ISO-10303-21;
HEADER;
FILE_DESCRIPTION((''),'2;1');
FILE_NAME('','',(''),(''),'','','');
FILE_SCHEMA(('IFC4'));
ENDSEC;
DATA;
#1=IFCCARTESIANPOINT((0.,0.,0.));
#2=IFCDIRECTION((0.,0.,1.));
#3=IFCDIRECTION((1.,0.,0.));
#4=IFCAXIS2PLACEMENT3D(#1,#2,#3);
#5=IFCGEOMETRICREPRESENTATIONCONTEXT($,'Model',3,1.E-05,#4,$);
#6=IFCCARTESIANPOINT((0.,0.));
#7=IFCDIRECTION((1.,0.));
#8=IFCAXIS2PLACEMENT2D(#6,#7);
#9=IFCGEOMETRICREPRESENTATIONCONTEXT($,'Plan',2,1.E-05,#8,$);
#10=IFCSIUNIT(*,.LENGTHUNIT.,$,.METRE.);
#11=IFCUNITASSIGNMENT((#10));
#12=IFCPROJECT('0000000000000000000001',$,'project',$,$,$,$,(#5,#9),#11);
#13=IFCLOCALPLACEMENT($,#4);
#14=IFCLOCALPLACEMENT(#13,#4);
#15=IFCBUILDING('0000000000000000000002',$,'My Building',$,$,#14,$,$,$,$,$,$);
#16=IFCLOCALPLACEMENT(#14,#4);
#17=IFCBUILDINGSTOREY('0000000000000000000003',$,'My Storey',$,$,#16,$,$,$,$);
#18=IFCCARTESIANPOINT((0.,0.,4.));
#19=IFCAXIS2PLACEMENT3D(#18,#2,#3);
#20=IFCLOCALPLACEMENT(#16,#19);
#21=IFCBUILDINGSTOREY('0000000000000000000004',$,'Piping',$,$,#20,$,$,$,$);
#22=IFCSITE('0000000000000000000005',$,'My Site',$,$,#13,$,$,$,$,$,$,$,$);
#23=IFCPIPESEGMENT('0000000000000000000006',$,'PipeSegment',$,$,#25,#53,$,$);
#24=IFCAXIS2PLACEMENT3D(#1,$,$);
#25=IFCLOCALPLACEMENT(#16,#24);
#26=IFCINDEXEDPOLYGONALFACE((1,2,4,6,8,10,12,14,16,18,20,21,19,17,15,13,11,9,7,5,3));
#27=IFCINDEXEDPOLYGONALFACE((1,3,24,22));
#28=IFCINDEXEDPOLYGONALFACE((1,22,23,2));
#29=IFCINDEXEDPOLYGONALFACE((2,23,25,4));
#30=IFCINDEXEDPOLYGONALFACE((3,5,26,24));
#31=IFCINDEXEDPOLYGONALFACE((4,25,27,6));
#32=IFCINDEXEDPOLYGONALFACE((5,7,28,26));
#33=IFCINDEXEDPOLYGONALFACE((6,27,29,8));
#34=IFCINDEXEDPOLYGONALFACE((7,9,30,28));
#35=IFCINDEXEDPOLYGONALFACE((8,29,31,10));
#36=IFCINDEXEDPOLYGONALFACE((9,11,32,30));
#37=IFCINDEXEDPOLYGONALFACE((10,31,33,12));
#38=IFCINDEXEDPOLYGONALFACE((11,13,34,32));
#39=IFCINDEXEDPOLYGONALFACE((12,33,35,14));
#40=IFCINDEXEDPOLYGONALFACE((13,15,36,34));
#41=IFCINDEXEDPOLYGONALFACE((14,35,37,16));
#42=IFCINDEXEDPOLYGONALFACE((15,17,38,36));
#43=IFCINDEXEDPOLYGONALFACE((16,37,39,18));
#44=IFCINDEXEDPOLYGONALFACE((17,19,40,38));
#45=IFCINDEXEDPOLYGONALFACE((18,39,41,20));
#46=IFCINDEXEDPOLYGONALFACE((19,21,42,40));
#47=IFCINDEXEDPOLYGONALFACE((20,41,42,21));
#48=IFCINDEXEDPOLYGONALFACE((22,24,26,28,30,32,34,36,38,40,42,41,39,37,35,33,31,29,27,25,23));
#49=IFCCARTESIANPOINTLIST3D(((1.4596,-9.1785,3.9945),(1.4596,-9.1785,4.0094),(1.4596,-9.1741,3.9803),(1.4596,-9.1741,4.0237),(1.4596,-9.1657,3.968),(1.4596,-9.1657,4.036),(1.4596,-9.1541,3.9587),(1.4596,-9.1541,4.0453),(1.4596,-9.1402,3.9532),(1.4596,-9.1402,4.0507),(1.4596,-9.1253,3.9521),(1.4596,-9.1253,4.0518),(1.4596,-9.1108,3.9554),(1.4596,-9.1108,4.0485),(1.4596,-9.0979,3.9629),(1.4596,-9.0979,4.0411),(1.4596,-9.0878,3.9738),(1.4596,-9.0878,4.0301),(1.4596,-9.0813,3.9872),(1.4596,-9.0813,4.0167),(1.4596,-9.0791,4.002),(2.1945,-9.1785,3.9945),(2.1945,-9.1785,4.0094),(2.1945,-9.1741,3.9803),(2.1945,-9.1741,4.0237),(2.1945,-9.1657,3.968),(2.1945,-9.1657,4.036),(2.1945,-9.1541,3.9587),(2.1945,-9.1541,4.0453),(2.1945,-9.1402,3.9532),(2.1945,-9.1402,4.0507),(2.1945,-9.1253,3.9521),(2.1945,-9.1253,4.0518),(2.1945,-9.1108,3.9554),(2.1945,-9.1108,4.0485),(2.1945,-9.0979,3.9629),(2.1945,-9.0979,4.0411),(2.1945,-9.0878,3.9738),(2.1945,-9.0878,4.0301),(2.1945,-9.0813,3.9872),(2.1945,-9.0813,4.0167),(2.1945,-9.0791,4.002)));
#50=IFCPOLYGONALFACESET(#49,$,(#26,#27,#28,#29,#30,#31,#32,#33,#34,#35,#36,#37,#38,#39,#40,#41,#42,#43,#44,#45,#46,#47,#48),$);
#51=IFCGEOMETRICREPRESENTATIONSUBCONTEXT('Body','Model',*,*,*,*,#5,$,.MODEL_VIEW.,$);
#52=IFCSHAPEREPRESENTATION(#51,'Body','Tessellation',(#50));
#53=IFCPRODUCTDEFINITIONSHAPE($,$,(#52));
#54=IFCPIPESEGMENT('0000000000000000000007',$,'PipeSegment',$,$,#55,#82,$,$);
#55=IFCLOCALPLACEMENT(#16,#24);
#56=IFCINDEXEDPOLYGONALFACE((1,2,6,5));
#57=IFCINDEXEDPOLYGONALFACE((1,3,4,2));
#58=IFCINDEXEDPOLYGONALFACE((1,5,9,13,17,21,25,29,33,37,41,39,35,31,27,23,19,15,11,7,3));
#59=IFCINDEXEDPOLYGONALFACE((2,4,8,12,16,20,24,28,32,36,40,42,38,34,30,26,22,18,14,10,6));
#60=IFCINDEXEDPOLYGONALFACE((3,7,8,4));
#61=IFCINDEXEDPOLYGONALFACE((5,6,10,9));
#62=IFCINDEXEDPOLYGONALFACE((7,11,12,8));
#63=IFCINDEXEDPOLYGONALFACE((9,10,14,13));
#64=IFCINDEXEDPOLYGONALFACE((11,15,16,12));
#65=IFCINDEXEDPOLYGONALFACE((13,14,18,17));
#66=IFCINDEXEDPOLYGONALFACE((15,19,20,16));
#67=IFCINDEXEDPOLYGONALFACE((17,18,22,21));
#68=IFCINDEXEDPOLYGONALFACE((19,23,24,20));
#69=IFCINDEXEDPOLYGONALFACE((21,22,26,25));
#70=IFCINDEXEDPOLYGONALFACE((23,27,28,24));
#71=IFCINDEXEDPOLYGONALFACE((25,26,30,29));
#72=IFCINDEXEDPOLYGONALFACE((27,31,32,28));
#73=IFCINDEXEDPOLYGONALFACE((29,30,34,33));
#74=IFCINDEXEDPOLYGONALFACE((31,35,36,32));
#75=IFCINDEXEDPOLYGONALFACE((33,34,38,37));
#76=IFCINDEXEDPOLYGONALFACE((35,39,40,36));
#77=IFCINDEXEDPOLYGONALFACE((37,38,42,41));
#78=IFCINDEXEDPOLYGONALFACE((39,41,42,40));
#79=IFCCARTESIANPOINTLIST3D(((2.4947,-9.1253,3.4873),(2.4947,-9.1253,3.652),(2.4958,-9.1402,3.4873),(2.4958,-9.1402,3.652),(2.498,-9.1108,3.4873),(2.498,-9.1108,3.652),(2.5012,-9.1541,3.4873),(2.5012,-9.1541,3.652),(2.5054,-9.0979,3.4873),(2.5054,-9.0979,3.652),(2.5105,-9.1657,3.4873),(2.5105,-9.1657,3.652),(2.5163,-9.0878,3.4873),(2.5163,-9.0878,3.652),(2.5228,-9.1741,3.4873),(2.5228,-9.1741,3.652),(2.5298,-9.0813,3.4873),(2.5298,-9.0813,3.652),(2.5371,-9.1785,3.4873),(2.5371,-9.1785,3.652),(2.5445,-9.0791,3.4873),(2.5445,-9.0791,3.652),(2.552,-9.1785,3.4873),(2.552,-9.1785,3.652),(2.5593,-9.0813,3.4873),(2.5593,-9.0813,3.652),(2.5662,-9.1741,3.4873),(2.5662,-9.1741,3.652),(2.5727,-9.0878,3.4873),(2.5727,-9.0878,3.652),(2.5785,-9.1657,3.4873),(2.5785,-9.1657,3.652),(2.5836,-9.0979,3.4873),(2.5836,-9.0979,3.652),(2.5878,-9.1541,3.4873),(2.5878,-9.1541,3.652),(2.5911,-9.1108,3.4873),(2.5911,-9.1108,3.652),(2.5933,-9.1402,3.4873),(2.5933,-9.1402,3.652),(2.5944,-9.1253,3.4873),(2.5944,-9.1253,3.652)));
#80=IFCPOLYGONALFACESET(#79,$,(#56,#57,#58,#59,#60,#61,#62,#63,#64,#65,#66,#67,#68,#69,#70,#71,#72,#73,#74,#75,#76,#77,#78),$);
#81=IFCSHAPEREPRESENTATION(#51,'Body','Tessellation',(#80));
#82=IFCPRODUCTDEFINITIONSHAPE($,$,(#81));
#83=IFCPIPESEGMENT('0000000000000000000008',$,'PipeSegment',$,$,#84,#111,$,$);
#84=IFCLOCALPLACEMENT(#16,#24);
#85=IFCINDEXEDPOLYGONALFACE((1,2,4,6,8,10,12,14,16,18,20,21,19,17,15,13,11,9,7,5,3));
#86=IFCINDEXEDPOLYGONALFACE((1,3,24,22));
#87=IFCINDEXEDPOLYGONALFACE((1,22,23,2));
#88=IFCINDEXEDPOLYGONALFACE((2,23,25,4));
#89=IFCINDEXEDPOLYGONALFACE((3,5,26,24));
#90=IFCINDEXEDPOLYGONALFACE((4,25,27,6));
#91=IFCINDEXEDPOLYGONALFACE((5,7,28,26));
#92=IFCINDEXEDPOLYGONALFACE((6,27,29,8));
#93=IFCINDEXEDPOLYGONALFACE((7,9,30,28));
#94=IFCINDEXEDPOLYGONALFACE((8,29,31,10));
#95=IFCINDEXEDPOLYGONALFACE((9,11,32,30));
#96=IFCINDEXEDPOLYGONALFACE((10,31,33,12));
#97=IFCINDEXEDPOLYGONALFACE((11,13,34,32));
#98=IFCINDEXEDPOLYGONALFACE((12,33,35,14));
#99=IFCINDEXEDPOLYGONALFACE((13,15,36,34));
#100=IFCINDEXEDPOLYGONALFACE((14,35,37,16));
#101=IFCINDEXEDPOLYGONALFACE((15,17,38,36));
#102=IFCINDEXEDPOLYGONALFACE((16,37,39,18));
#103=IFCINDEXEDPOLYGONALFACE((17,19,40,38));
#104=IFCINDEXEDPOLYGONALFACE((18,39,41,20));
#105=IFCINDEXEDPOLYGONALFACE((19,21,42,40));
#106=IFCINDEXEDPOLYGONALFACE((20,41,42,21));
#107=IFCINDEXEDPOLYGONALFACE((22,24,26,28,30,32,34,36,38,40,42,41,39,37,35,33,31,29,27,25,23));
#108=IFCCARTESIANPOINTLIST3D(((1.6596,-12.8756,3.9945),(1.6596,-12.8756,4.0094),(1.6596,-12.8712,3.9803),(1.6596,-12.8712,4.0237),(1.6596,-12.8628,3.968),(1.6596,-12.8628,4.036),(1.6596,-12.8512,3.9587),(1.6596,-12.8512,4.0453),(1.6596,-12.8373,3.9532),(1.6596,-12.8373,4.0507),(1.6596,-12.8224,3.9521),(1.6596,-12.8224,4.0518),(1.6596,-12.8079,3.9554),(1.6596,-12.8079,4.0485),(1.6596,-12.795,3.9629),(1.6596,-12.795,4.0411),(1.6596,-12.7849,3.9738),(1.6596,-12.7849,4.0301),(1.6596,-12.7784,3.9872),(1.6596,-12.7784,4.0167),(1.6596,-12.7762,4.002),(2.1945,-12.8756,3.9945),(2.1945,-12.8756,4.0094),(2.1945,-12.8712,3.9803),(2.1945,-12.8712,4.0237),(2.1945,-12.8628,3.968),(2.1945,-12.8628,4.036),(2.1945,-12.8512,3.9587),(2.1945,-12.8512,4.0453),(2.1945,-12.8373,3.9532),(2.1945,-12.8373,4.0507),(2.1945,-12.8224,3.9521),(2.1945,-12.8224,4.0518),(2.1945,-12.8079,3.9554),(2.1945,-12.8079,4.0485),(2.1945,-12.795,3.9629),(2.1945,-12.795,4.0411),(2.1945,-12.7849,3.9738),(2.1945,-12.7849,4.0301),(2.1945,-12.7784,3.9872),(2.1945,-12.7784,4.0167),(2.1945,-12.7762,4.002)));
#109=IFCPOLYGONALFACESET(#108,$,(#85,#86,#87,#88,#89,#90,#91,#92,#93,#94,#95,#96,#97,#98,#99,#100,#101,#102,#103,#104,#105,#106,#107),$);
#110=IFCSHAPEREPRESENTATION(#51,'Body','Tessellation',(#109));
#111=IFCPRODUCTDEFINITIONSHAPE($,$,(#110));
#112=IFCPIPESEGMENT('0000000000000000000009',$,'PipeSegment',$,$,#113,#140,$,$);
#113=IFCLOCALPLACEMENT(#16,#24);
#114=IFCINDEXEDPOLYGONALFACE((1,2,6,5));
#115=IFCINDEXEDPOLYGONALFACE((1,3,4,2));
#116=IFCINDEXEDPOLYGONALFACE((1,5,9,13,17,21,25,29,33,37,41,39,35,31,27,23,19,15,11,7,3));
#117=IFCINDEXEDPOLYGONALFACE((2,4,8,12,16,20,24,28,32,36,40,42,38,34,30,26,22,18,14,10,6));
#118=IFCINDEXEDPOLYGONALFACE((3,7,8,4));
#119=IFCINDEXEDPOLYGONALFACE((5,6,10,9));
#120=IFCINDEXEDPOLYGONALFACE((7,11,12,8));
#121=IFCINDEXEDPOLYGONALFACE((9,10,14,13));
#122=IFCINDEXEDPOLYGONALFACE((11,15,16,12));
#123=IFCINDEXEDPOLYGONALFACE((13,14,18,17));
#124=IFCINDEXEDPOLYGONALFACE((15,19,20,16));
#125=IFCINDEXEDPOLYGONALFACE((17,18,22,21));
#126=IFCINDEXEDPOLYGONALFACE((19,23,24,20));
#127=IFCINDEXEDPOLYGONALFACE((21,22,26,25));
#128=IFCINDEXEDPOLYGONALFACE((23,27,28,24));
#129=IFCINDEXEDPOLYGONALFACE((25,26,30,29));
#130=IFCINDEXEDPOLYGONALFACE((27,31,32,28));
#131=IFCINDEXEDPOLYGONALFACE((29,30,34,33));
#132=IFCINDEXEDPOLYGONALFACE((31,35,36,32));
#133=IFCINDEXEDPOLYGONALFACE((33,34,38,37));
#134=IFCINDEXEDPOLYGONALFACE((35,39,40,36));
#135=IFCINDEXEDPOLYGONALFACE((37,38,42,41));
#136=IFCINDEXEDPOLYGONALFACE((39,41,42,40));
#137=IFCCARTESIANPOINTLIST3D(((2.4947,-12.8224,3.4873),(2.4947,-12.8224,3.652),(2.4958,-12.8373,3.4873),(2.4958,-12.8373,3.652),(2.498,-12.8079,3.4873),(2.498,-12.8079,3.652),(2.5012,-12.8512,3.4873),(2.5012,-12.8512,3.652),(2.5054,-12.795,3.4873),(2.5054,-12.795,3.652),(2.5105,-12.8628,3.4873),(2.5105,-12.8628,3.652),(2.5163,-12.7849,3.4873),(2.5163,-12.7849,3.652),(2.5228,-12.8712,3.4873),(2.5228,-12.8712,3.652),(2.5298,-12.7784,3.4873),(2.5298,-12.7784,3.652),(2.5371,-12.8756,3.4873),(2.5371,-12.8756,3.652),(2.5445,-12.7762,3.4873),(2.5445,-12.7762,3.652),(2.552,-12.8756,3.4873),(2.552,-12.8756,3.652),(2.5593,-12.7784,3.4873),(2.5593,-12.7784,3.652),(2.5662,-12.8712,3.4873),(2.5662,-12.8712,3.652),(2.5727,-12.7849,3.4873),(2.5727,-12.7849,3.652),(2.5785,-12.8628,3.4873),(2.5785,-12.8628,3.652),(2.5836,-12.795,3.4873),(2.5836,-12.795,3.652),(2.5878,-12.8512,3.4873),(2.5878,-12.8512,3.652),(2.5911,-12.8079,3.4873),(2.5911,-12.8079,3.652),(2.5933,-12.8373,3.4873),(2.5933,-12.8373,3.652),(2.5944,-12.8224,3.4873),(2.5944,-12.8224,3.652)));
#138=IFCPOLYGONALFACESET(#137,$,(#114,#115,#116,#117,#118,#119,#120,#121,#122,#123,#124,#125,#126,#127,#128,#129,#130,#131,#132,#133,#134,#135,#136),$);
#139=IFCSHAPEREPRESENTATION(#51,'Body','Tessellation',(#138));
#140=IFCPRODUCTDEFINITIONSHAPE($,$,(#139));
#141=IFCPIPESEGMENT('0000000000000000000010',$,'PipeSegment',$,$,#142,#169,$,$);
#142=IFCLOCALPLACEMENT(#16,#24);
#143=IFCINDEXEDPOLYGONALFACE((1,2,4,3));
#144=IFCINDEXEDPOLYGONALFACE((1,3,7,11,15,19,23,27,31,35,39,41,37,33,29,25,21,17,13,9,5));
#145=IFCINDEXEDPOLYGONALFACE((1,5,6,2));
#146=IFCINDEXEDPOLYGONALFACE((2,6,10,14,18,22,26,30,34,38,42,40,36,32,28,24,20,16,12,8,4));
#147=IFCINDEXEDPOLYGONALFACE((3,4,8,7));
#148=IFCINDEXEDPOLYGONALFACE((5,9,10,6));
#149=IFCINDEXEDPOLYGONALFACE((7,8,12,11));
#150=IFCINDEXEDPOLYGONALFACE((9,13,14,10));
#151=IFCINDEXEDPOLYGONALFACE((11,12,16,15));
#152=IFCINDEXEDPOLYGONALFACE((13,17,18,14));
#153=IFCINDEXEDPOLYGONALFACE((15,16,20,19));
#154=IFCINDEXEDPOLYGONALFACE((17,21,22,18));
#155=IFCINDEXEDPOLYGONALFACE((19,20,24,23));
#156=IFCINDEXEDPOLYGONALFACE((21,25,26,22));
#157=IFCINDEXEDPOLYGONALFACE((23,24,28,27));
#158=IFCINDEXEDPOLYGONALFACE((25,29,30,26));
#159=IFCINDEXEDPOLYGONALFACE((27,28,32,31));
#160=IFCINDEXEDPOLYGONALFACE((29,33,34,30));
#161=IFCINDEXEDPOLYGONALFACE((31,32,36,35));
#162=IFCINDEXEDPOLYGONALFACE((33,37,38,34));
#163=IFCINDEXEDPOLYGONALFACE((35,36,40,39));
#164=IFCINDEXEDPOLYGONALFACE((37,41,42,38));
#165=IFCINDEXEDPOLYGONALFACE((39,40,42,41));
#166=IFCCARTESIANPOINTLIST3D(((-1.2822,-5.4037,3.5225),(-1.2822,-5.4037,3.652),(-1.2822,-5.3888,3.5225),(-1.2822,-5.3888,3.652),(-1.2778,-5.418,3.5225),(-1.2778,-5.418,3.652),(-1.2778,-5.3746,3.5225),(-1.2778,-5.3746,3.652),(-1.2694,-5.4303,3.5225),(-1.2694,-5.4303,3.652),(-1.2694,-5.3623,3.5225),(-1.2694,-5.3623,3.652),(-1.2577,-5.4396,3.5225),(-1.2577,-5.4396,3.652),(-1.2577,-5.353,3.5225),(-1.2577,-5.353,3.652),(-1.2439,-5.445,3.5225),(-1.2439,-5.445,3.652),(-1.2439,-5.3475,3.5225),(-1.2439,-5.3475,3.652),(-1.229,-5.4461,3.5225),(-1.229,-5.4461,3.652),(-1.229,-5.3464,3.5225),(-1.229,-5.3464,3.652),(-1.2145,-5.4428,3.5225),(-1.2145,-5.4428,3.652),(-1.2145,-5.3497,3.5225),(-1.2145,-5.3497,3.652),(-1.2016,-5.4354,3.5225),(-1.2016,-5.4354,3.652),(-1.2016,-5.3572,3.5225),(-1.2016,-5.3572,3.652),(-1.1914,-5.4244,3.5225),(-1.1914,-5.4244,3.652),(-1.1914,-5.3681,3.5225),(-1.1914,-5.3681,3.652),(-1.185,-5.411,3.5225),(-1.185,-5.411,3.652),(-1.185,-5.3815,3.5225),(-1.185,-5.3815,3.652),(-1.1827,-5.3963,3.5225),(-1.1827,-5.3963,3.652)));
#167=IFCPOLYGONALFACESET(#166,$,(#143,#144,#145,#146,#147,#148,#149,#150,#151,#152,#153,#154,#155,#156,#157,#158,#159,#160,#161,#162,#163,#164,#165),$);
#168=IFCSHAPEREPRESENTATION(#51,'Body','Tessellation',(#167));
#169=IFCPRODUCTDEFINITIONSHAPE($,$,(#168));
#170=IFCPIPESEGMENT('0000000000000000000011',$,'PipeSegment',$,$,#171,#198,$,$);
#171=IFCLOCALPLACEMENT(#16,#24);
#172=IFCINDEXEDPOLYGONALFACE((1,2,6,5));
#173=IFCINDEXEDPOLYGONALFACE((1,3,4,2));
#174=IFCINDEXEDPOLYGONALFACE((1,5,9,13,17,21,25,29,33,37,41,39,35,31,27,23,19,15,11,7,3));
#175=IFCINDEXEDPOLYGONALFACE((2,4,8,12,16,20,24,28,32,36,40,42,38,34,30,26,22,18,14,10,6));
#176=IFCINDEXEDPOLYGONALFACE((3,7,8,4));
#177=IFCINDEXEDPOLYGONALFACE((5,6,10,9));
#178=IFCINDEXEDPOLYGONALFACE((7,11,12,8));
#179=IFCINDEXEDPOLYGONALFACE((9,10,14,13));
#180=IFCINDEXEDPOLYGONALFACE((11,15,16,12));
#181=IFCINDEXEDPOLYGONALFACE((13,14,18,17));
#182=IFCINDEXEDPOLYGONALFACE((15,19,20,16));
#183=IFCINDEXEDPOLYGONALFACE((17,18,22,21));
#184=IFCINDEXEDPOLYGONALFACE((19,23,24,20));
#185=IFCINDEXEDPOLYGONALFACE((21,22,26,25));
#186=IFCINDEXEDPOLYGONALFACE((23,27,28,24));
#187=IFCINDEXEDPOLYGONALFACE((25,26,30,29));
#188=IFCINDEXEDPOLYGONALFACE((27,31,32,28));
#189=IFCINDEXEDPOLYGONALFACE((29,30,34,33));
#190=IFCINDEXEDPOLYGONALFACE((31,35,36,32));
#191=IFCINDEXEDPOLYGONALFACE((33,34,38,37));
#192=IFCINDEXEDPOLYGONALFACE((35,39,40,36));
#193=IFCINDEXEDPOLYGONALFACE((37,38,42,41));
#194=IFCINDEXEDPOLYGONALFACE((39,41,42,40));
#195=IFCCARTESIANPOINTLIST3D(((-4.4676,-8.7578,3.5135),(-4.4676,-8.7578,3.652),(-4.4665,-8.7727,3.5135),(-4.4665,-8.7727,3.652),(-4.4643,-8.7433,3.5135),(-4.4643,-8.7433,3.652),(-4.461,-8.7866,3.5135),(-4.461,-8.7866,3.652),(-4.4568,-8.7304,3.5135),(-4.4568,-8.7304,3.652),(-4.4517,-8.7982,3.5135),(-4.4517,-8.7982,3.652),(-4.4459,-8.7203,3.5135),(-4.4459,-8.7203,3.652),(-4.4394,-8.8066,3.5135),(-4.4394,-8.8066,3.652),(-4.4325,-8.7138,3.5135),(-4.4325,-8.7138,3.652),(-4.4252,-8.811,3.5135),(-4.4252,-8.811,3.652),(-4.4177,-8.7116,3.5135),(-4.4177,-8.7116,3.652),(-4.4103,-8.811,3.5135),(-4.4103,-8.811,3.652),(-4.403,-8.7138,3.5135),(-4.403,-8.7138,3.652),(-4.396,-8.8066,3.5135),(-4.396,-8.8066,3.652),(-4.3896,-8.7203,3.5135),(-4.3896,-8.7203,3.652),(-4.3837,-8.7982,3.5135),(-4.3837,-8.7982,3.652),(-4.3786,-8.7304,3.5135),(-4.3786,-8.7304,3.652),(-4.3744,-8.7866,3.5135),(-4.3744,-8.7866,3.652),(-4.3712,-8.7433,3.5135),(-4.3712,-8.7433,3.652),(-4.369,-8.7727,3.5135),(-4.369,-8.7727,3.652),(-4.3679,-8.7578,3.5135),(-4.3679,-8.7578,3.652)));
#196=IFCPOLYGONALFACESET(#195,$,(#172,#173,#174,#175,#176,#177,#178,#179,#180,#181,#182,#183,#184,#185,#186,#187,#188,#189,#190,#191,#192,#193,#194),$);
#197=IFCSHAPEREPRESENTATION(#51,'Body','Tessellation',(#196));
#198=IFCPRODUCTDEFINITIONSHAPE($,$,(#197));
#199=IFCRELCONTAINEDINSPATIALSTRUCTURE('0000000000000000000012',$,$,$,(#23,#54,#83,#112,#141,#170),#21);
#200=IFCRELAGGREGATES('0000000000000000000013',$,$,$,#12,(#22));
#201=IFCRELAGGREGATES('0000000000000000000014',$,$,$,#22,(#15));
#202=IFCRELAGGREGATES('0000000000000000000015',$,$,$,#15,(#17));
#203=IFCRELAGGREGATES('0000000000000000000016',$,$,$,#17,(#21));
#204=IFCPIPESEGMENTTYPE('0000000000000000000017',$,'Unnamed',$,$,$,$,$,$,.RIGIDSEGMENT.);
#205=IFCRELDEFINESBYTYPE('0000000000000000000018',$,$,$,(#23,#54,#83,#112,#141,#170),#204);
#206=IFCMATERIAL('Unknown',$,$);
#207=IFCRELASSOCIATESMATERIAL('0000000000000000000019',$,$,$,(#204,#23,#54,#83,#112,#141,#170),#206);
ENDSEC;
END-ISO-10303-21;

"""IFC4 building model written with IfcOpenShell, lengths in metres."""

from ifc_helpers import new_model, si_unit, frame, origin_with_axes, origin_2d_with_axis, place, context, subcontext, project, spatial, circle, extrude, material, material_profile, profile_set, profile_usage, type_object, element, save


model = new_model("IFC4")

# Units and contexts
model_context = context("Model", 3, precision=1e-05, world=origin_with_axes())
plan_context = context("Plan", 2, precision=1e-05, world=origin_2d_with_axis())
body_context = subcontext(model_context, "Body", "Model", "MODEL_VIEW")
ifc_project = project(units=[si_unit("LENGTHUNIT", "METRE")], contexts=[model_context, plan_context])

# Site, building, storeys
site_placement = place(None, origin_with_axes())
site = spatial("IfcSite", under=ifc_project, at=site_placement, Name="My Site")
building_placement = place(site_placement, origin_with_axes())
building = spatial("IfcBuilding", under=site, at=building_placement, Name="My Building")
storey_1_placement = place(building_placement, origin_with_axes())
storey_1 = spatial("IfcBuildingStorey", under=building, at=storey_1_placement, Name="My Storey")
storey_2_placement = place(storey_1_placement, frame((0.0, 0.0, 4.0), z_axis=(0.0, 0.0, 1.0), x_axis=(1.0, 0.0, 0.0)))
storey_2 = spatial("IfcBuildingStorey", under=storey_1, at=storey_2_placement, Name="Piping")

# Pipe segments
ifc_material = material(Name="Unknown")
ifc_material_profile_1 = material_profile(ifc_material, circle(Radius=0.05))
ifc_profile_set_1 = profile_set([ifc_material_profile_1])
ifc_profile_usage_1 = profile_usage(ifc_profile_set_1, cardinal=5)
pipe_segment_type = type_object("IfcPipeSegmentType", Name="Unnamed", PredefinedType="RIGIDSEGMENT", material=ifc_profile_set_1)
pipe_segment_1_placement = place(storey_2_placement, frame((1.4596, -9.1291, 0.002), z_axis=(1.0, 0.0, 0.0), x_axis=(0.0, 1.0, 0.0)))
element("IfcPipeSegment", 1, at=pipe_segment_1_placement, inside=storey_2, type_object=pipe_segment_type, material=ifc_profile_usage_1, Name="PipeSegment", context=body_context, shape_type="SweptSolid", body=[
    extrude(circle(Radius=0.05), origin_with_axes(), (0.0, 0.0, 1.0), 0.735),
])
ifc_profile_usage_2 = profile_usage(ifc_profile_set_1, cardinal=5)
pipe_segment_2_placement = place(storey_2_placement, frame((2.5445, -9.1291, -0.348), z_axis=(0.0, 0.0, -1.0), x_axis=(0.0, 1.0, 0.0)))
element("IfcPipeSegment", 2, at=pipe_segment_2_placement, inside=storey_2, type_object=pipe_segment_type, material=ifc_profile_usage_2, Name="PipeSegment", context=body_context, shape_type="SweptSolid", body=[
    extrude(circle(Radius=0.05), origin_with_axes(), (0.0, 0.0, 1.0), 0.1647),
])
ifc_profile_usage_3 = profile_usage(ifc_profile_set_1, cardinal=5)
pipe_segment_3_placement = place(storey_2_placement, frame((1.6596, -12.8262, 0.002), z_axis=(1.0, 0.0, 0.0), x_axis=(0.0, 1.0, 0.0)))
element("IfcPipeSegment", 3, at=pipe_segment_3_placement, inside=storey_2, type_object=pipe_segment_type, material=ifc_profile_usage_3, Name="PipeSegment", context=body_context, shape_type="SweptSolid", body=[
    extrude(circle(Radius=0.05), origin_with_axes(), (0.0, 0.0, 1.0), 0.535),
])
ifc_profile_usage_4 = profile_usage(ifc_profile_set_1, cardinal=5)
pipe_segment_4_placement = place(storey_2_placement, frame((2.5445, -12.8262, -0.348), z_axis=(0.0, 0.0, -1.0), x_axis=(0.0, 1.0, 0.0)))
element("IfcPipeSegment", 4, at=pipe_segment_4_placement, inside=storey_2, type_object=pipe_segment_type, material=ifc_profile_usage_4, Name="PipeSegment", context=body_context, shape_type="SweptSolid", body=[
    extrude(circle(Radius=0.05), origin_with_axes(), (0.0, 0.0, 1.0), 0.1647),
])
ifc_profile_usage_5 = profile_usage(ifc_profile_set_1, cardinal=5)
pipe_segment_5_placement = place(storey_2_placement, frame((-1.2327, -5.3963, -0.348), z_axis=(0.0, 0.0, -1.0), x_axis=(1.0, 0.0, 0.0)))
element("IfcPipeSegment", 5, at=pipe_segment_5_placement, inside=storey_2, type_object=pipe_segment_type, material=ifc_profile_usage_5, Name="PipeSegment", context=body_context, shape_type="SweptSolid", body=[
    extrude(circle(Radius=0.05), origin_with_axes(), (0.0, 0.0, 1.0), 0.1294),
])
ifc_profile_usage_6 = profile_usage(ifc_profile_set_1, cardinal=5)
pipe_segment_6_placement = place(storey_2_placement, frame((-4.4177, -8.7616, -0.348), z_axis=(0.0, 0.0, -1.0), x_axis=(0.0, 1.0, 0.0)))
element("IfcPipeSegment", 6, at=pipe_segment_6_placement, inside=storey_2, type_object=pipe_segment_type, material=ifc_profile_usage_6, Name="PipeSegment", context=body_context, shape_type="SweptSolid", body=[
    extrude(circle(Radius=0.05), origin_with_axes(), (0.0, 0.0, 1.0), 0.1385),
])

save(model, "model.ifc")
